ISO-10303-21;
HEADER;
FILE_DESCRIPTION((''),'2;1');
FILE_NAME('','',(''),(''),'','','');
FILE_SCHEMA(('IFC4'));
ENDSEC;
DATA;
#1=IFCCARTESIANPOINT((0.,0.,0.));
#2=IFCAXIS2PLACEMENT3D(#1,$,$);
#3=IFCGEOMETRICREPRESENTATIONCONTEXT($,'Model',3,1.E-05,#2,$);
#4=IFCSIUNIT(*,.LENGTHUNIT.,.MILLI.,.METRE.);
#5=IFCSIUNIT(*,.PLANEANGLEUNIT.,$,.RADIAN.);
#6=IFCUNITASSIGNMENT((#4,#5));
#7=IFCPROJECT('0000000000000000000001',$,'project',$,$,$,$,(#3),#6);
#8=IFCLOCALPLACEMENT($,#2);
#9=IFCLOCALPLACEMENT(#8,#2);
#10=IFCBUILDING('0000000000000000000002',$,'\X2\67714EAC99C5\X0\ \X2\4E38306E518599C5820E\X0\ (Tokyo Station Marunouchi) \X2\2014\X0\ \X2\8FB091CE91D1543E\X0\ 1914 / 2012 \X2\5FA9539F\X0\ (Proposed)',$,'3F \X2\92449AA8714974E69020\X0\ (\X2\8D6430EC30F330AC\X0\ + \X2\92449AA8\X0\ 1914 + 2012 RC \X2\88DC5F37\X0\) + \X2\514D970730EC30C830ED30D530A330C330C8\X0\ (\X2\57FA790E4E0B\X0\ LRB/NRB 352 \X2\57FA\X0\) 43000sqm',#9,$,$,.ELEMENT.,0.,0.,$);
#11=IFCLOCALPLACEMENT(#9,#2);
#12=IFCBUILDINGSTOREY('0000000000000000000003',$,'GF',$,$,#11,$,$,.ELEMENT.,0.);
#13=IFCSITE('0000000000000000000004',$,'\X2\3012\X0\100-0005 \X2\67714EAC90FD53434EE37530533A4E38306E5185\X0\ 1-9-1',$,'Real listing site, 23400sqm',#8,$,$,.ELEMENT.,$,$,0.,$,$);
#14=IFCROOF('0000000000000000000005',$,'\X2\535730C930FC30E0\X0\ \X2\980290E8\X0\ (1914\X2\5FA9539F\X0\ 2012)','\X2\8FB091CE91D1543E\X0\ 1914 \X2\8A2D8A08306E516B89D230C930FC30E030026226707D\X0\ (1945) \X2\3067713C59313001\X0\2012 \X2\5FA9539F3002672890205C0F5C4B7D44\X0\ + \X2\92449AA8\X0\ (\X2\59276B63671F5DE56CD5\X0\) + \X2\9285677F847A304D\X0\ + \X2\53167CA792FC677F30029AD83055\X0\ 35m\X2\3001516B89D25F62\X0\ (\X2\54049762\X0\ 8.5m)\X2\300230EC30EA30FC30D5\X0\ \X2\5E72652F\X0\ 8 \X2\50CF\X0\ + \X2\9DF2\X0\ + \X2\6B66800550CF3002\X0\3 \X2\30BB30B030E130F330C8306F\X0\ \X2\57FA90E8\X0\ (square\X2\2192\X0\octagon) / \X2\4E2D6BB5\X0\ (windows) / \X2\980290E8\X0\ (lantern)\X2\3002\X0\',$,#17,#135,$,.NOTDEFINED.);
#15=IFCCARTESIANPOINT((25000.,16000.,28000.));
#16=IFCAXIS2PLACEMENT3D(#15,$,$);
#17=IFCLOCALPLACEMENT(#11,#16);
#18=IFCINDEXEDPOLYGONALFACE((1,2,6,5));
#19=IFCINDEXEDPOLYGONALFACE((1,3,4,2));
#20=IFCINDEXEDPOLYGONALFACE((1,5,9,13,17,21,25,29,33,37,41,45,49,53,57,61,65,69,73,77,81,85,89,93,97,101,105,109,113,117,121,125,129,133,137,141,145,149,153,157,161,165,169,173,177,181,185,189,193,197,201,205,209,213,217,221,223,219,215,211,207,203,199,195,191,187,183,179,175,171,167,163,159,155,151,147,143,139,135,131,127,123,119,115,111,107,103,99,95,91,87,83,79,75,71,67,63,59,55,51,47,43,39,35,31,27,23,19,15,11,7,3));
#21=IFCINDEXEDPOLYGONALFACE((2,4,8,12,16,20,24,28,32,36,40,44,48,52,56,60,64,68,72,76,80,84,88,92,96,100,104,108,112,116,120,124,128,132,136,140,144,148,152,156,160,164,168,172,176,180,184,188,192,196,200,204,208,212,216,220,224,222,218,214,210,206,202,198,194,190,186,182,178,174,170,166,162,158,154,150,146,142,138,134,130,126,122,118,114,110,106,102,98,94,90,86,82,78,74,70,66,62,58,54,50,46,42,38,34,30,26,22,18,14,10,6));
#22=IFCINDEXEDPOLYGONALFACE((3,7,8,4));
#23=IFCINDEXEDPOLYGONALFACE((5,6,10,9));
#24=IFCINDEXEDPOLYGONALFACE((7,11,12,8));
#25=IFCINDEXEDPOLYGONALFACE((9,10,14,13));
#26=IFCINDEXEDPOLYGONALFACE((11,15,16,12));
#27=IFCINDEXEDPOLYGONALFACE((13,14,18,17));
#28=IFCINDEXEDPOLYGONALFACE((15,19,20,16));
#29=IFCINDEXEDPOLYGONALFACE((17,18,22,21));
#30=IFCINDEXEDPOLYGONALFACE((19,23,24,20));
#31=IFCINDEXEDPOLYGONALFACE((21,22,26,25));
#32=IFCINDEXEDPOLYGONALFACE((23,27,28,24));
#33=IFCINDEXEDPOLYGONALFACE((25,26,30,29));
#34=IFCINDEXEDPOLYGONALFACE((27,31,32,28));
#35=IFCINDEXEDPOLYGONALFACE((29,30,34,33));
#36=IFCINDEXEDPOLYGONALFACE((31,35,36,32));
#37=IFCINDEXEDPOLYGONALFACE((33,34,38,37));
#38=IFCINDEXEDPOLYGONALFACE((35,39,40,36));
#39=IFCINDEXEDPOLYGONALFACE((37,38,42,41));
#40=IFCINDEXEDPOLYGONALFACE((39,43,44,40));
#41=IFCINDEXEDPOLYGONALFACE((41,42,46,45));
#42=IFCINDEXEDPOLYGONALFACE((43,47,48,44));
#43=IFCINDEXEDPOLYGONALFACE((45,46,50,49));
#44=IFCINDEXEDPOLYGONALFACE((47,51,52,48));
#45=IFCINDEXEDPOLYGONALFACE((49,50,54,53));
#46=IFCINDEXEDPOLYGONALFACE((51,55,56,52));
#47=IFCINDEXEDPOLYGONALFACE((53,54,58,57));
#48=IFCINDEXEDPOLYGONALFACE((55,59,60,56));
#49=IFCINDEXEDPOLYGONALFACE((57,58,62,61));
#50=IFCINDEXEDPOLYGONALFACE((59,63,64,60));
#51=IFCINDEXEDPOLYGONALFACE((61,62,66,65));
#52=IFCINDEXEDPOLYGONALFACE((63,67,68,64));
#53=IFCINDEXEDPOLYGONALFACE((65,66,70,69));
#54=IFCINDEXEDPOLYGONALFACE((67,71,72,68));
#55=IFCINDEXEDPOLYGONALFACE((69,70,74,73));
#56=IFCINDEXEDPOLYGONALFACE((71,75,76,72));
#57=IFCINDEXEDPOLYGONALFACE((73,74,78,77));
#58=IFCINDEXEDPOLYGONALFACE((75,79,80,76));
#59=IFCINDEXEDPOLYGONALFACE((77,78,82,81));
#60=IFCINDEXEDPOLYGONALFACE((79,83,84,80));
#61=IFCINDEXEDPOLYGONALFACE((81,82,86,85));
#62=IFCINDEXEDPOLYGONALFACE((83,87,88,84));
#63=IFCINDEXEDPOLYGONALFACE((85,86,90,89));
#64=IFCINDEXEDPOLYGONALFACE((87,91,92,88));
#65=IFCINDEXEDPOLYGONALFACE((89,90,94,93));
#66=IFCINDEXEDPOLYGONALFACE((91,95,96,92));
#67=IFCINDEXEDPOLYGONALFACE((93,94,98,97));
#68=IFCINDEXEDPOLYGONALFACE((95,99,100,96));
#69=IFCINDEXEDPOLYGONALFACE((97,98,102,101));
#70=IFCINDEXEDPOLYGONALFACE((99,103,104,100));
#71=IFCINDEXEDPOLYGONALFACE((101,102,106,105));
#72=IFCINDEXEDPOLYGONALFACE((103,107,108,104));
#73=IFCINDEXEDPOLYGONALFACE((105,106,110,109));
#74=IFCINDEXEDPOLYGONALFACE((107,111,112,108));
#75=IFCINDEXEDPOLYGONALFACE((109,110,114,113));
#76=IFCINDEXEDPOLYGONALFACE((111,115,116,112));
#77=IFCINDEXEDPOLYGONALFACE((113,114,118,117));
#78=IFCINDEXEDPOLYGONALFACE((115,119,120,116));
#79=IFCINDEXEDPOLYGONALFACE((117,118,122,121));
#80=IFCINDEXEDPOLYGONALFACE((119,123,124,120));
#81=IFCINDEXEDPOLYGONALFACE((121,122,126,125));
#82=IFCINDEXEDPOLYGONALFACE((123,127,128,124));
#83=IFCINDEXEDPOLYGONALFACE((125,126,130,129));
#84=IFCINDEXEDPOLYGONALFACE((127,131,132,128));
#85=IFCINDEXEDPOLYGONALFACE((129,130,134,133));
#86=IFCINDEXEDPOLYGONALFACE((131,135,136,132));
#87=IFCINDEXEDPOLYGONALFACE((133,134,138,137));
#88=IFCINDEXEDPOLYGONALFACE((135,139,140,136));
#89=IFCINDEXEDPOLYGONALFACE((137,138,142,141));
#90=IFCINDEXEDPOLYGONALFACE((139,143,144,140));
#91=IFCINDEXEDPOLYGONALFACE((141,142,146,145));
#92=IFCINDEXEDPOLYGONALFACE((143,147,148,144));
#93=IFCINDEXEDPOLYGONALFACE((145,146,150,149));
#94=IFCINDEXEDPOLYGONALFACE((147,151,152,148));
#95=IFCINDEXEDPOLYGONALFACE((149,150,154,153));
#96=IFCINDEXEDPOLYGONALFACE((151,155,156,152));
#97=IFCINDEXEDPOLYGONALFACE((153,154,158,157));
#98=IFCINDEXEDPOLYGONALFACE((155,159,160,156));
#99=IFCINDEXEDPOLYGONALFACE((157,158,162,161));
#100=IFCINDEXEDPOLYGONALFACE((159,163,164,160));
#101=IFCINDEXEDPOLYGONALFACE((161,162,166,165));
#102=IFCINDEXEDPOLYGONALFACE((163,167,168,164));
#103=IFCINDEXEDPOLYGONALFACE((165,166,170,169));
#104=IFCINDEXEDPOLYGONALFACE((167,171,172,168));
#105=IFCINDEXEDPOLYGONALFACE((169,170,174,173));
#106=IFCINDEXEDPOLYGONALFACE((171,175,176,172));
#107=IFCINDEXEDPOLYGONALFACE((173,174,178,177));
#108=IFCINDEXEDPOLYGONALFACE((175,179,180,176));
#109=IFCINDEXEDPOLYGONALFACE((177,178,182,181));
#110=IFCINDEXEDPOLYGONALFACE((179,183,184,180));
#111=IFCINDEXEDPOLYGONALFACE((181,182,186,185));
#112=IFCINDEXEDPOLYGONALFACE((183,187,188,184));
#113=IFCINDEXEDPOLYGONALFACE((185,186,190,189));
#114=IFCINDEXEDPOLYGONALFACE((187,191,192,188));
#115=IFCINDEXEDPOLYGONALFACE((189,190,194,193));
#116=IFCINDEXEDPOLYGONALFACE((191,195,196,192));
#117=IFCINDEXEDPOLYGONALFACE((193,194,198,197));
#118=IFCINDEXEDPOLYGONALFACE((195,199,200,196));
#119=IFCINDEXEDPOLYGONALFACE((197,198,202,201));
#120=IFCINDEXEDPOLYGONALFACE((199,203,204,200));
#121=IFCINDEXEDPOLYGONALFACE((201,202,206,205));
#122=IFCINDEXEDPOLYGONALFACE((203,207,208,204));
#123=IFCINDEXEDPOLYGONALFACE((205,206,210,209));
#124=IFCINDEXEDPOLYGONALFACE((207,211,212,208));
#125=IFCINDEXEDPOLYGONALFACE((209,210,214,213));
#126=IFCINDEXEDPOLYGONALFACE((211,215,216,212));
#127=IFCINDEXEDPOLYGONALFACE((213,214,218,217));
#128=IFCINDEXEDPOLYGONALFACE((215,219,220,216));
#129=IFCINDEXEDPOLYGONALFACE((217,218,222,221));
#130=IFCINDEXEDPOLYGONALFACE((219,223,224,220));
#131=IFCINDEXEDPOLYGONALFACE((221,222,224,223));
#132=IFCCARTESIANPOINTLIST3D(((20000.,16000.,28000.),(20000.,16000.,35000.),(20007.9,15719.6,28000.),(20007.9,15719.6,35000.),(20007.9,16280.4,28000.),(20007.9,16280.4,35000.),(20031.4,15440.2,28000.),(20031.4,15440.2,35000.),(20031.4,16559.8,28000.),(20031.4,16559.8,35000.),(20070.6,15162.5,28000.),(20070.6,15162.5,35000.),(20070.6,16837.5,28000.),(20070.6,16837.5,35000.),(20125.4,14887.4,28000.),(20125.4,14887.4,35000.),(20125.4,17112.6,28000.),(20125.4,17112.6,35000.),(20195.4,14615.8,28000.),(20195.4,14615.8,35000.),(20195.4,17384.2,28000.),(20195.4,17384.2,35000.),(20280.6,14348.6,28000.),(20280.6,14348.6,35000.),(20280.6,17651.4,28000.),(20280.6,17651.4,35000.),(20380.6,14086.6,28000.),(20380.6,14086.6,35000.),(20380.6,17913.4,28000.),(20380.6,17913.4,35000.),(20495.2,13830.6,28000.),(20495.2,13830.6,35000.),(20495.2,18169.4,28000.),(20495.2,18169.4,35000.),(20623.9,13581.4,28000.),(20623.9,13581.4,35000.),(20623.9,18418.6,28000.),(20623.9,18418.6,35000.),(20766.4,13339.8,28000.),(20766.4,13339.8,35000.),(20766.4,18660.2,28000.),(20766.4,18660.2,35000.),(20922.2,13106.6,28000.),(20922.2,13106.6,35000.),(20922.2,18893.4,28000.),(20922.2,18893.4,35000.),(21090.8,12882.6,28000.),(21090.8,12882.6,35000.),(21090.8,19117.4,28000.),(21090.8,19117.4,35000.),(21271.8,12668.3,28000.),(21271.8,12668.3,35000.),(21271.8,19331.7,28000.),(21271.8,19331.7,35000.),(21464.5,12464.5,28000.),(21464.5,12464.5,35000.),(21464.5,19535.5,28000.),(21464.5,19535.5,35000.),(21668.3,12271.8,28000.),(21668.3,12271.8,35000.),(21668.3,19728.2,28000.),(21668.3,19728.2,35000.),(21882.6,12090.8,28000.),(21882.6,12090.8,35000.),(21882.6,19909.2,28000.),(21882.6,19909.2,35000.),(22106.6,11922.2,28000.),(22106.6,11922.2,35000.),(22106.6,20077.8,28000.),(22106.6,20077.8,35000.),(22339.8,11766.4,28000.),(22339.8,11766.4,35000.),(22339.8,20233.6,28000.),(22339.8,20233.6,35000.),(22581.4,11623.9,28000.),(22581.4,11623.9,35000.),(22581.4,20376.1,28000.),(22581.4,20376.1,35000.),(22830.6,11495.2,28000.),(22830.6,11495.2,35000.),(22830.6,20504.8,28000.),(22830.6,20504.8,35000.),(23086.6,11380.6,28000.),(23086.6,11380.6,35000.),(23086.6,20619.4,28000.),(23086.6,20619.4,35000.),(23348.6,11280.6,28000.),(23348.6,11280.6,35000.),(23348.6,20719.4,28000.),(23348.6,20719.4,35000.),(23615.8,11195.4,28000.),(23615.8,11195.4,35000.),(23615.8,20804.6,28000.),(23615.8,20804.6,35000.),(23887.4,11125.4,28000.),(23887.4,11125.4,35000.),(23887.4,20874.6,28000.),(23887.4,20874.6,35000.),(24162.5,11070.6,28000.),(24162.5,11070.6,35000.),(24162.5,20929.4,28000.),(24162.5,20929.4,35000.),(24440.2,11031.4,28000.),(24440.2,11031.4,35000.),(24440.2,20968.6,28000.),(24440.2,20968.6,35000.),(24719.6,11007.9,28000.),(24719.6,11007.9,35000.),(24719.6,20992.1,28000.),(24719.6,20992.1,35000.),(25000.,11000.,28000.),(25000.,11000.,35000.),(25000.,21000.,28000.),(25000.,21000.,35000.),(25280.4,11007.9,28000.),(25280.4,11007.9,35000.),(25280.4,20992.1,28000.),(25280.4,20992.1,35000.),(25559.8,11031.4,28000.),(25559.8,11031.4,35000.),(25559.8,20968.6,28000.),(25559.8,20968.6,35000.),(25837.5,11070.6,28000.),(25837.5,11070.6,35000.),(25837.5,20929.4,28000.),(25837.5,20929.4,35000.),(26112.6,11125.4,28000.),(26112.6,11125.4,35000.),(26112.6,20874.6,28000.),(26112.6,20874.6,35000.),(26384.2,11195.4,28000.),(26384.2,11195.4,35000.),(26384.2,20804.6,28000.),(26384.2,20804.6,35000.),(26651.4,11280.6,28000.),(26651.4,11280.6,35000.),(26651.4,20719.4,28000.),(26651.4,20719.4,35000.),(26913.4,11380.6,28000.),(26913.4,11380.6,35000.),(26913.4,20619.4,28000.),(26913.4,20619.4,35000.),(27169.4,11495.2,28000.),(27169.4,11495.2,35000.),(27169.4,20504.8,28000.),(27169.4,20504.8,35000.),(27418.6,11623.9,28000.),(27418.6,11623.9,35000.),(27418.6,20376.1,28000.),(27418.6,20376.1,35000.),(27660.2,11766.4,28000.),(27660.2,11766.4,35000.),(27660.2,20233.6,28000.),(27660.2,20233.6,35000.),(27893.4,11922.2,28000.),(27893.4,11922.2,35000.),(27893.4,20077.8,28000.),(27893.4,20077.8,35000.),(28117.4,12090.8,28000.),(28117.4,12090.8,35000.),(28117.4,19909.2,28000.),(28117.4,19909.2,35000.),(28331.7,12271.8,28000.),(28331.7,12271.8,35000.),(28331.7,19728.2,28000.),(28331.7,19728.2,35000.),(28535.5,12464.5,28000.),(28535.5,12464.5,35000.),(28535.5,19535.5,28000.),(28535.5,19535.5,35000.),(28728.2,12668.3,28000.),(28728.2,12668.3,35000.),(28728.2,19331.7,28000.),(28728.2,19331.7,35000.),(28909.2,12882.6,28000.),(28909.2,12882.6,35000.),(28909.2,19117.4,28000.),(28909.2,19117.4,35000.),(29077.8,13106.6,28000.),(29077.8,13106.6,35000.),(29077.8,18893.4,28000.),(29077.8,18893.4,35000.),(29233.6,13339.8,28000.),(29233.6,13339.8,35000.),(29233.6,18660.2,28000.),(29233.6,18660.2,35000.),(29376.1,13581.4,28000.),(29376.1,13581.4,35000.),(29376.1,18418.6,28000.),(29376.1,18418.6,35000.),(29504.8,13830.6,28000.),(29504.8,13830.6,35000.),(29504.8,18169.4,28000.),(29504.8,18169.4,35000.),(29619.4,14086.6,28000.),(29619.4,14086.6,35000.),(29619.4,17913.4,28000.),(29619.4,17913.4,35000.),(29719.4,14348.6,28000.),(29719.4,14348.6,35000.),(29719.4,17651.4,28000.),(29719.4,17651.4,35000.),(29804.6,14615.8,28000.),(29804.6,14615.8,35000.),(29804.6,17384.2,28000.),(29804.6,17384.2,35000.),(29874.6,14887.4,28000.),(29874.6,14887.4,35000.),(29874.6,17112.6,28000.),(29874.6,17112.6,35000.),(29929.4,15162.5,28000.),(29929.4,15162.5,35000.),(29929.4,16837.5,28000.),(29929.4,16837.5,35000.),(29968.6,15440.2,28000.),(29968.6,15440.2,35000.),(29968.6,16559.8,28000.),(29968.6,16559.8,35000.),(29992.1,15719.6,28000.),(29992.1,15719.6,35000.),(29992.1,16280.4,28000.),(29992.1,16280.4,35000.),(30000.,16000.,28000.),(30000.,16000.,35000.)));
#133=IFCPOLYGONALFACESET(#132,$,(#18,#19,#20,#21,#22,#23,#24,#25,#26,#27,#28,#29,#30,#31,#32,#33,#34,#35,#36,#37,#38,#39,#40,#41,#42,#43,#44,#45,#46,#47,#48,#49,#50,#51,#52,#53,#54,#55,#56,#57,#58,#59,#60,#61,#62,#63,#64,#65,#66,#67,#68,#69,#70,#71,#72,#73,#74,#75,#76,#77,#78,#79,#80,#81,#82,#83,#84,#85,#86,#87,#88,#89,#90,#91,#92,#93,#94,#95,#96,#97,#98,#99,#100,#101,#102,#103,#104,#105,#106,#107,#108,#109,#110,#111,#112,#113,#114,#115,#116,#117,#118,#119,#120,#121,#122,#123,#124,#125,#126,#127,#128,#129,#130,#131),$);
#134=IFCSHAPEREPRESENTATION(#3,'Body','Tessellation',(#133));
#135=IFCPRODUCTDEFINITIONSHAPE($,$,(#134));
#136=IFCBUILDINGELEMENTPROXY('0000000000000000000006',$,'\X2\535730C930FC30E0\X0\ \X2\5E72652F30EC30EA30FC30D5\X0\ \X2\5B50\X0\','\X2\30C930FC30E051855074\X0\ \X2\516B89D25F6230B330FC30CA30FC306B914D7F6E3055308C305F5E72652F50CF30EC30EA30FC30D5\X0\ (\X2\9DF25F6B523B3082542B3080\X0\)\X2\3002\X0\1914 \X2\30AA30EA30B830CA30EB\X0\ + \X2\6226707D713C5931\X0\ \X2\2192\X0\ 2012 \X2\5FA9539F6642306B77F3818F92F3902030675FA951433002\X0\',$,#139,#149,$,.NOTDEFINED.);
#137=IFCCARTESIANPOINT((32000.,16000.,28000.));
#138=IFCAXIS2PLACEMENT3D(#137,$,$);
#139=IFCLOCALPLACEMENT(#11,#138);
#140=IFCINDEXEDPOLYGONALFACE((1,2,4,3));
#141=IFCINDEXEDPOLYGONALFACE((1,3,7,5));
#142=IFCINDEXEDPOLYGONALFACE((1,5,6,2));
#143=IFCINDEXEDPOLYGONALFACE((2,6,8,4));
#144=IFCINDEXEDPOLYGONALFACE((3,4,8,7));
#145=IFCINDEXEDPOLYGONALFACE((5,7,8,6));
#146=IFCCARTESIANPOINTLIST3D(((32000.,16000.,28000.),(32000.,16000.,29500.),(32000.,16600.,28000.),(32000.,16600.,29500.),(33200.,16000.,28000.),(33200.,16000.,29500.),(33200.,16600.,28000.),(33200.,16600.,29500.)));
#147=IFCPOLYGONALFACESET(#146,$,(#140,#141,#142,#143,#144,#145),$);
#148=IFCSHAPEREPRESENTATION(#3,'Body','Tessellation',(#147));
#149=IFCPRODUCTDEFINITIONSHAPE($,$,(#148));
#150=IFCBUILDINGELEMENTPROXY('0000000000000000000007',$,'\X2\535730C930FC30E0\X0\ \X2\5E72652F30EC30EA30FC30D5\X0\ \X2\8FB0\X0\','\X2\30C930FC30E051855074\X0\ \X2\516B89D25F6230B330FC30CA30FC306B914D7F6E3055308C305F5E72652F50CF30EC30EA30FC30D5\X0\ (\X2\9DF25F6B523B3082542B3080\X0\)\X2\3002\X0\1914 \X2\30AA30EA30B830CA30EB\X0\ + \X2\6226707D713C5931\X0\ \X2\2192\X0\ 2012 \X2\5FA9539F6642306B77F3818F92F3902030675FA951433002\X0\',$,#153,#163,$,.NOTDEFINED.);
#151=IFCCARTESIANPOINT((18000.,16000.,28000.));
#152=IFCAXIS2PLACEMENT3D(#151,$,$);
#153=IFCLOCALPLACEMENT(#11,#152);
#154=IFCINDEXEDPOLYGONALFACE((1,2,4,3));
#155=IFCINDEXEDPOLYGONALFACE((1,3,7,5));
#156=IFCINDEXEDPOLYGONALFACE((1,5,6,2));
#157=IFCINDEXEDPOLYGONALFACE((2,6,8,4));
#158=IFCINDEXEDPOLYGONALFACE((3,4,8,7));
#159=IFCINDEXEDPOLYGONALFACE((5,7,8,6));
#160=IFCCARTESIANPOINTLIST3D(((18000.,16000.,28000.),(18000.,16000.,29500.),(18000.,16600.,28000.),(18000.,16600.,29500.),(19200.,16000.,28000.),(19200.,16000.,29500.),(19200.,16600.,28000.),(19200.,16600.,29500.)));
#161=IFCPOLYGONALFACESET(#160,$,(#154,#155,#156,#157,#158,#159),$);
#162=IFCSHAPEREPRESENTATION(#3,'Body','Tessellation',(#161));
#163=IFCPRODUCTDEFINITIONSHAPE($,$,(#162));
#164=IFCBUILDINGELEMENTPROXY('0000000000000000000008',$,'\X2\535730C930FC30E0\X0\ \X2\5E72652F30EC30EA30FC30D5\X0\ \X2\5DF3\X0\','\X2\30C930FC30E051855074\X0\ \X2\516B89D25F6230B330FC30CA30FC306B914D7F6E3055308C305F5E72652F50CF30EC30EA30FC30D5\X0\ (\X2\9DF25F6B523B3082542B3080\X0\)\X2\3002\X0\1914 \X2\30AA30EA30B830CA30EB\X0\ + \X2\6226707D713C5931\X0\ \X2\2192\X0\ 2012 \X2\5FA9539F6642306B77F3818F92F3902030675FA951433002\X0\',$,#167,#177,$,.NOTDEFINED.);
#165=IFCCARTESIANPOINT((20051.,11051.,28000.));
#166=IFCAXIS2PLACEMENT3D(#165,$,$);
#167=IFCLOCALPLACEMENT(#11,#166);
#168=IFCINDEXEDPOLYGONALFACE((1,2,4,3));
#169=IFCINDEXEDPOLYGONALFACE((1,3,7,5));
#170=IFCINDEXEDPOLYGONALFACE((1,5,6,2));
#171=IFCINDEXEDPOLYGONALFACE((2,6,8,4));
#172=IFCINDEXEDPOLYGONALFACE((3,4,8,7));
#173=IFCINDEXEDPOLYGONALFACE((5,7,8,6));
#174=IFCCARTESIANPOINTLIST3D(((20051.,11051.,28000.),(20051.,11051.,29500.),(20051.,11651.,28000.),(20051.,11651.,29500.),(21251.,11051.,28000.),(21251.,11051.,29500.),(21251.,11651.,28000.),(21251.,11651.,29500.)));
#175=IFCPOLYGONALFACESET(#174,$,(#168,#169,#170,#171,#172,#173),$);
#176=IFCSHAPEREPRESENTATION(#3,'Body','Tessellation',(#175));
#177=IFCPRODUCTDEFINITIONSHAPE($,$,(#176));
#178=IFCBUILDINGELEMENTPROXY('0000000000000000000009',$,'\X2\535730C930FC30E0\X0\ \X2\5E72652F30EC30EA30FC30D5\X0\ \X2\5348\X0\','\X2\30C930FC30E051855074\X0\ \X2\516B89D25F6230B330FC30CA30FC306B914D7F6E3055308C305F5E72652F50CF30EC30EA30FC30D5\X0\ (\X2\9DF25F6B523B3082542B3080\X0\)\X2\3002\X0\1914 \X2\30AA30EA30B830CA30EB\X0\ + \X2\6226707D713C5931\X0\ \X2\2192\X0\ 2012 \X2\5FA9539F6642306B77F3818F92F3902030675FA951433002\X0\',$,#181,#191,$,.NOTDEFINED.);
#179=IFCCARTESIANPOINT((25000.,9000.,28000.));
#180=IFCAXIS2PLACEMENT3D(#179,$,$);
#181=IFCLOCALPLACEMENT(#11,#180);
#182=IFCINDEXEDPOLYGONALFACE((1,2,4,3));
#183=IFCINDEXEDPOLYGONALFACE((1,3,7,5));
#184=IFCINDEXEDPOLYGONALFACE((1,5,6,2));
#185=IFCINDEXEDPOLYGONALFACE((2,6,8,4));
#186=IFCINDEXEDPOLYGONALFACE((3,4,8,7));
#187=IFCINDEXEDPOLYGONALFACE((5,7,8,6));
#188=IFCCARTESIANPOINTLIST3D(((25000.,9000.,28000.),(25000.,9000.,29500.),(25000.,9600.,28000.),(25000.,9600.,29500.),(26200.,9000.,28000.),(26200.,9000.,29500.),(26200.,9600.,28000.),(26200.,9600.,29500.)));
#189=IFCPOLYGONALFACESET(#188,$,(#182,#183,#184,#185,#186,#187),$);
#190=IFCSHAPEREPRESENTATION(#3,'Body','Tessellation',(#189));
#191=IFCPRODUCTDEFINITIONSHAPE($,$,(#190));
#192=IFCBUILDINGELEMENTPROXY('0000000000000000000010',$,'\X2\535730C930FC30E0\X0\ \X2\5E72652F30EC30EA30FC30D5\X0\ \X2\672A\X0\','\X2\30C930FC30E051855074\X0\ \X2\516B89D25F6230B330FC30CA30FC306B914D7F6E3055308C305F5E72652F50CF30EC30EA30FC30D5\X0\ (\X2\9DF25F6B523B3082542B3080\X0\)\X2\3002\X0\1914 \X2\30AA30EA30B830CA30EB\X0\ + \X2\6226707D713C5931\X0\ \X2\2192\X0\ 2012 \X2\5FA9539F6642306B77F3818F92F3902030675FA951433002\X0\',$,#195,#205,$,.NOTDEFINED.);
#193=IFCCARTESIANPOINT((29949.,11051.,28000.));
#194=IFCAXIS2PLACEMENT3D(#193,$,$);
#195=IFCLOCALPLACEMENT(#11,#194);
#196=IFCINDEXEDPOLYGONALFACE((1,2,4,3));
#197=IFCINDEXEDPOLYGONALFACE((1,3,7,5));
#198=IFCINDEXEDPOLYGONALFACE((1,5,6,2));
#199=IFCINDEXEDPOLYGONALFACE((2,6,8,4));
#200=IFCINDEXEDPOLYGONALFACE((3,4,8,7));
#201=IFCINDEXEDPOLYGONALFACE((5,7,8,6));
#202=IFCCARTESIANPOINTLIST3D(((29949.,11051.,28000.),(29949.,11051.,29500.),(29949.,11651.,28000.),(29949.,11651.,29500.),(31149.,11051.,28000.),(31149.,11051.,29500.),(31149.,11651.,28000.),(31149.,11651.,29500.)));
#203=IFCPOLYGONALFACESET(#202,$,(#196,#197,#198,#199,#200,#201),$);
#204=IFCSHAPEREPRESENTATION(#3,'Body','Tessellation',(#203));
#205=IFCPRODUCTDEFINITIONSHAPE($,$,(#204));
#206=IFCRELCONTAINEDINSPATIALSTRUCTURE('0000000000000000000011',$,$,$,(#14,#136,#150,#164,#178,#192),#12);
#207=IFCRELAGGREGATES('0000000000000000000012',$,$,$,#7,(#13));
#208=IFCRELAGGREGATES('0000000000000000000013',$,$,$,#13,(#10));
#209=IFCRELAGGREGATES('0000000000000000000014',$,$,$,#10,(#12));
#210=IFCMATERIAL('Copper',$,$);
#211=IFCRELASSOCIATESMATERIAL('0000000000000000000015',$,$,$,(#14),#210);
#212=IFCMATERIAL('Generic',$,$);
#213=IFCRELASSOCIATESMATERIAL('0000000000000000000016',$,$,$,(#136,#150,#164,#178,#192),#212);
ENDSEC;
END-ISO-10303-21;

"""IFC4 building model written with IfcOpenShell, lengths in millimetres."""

from ifc_helpers import new_model, si_unit, frame, frame_2d, origin, origin_2d, place, context, project, spatial, rectangle, circle, extrude, material, element, save


model = new_model("IFC4")

# Units and contexts
model_context = context("Model", 3, precision=1e-05, world=origin())
ifc_project = project(units=[si_unit("LENGTHUNIT", "METRE", prefix="MILLI"), si_unit("PLANEANGLEUNIT", "RADIAN")], contexts=[model_context])

# Site, building, storey
site_placement = place(None, origin())
site = spatial("IfcSite", under=ifc_project, at=site_placement, Name="〒100-0005 東京都千代田区丸の内 1-9-1", ObjectType="Real listing site, 23400sqm", CompositionType="ELEMENT", RefElevation=0.0)
building_placement = place(site_placement, origin())
building = spatial("IfcBuilding", under=site, at=building_placement, Name="東京駅 丸の内駅舎 (Tokyo Station Marunouchi) — 辰野金吾 1914 / 2012 復原 (Proposed)", ObjectType="3F 鉄骨煉瓦造 (赤レンガ + 鉄骨 1914 + 2012 RC 補強) + 免震レトロフィット (基礎下 LRB/NRB 352 基) 43000sqm", CompositionType="ELEMENT", ElevationOfRefHeight=0.0, ElevationOfTerrain=0.0)
storey_placement = place(building_placement, origin())
storey = spatial("IfcBuildingStorey", under=building, at=storey_placement, Name="GF", CompositionType="ELEMENT", Elevation=0.0)

# Shared definitions
ifc_material_1 = material(Name="Generic")

# Roof
ifc_material_2 = material(Name="Copper")
roof_1_placement = place(storey_placement, frame((25000.0, 16000.0, 28000.0)))
element("IfcRoof", 1, at=roof_1_placement, inside=storey, material=ifc_material_2, Name="南ドーム 頂部 (1914復原 2012)", Description="辰野金吾 1914 設計の八角ドーム。戦災 (1945) で焼失、2012 復原。木造小屋組 + 鉄骨 (大正期工法) + 銅板葺き + 化粧鋼板。高さ 35m、八角形 (各面 8.5m)。レリーフ 干支 8 像 + 鷲 + 武者像。3 セグメントは 基部 (square→octagon) / 中段 (windows) / 頂部 (lantern)。", PredefinedType="NOTDEFINED", context=model_context, shape_type="SweptSolid", body=[
    extrude(circle(Radius=5000.0, at=origin_2d()), frame((25000.0, 16000.0, 28000.0)), (0.0, 0.0, 1.0), 7000.0),
])

# Building element proxies
proxy_1_placement = place(storey_placement, frame((32000.0, 16000.0, 28000.0)))
element("IfcBuildingElementProxy", 2, at=proxy_1_placement, inside=storey, material=ifc_material_1, Name="南ドーム 干支レリーフ 子", Description="ドーム内側 八角形コーナーに配置された干支像レリーフ (鷲彫刻も含む)。1914 オリジナル + 戦災焼失 → 2012 復原時に石膏鋳造で復元。", PredefinedType="NOTDEFINED", context=model_context, shape_type="SweptSolid", body=[
    extrude(rectangle(XDim=1200.0, YDim=600.0, at=frame_2d((600.0, 300.0))), frame((32000.0, 16000.0, 28000.0)), (0.0, 0.0, 1.0), 1500.0),
])
proxy_2_placement = place(storey_placement, frame((18000.0, 16000.0, 28000.0)))
element("IfcBuildingElementProxy", 3, at=proxy_2_placement, inside=storey, material=ifc_material_1, Name="南ドーム 干支レリーフ 辰", Description="ドーム内側 八角形コーナーに配置された干支像レリーフ (鷲彫刻も含む)。1914 オリジナル + 戦災焼失 → 2012 復原時に石膏鋳造で復元。", PredefinedType="NOTDEFINED", context=model_context, shape_type="SweptSolid", body=[
    extrude(rectangle(XDim=1200.0, YDim=600.0, at=frame_2d((600.0, 300.0))), frame((18000.0, 16000.0, 28000.0)), (0.0, 0.0, 1.0), 1500.0),
])
proxy_3_placement = place(storey_placement, frame((20051.0, 11051.0, 28000.0)))
element("IfcBuildingElementProxy", 4, at=proxy_3_placement, inside=storey, material=ifc_material_1, Name="南ドーム 干支レリーフ 巳", Description="ドーム内側 八角形コーナーに配置された干支像レリーフ (鷲彫刻も含む)。1914 オリジナル + 戦災焼失 → 2012 復原時に石膏鋳造で復元。", PredefinedType="NOTDEFINED", context=model_context, shape_type="SweptSolid", body=[
    extrude(rectangle(XDim=1200.0, YDim=600.0, at=frame_2d((600.0, 300.0))), frame((20051.0, 11051.0, 28000.0)), (0.0, 0.0, 1.0), 1500.0),
])
proxy_4_placement = place(storey_placement, frame((25000.0, 9000.0, 28000.0)))
element("IfcBuildingElementProxy", 5, at=proxy_4_placement, inside=storey, material=ifc_material_1, Name="南ドーム 干支レリーフ 午", Description="ドーム内側 八角形コーナーに配置された干支像レリーフ (鷲彫刻も含む)。1914 オリジナル + 戦災焼失 → 2012 復原時に石膏鋳造で復元。", PredefinedType="NOTDEFINED", context=model_context, shape_type="SweptSolid", body=[
    extrude(rectangle(XDim=1200.0, YDim=600.0, at=frame_2d((600.0, 300.0))), frame((25000.0, 9000.0, 28000.0)), (0.0, 0.0, 1.0), 1500.0),
])
proxy_5_placement = place(storey_placement, frame((29949.0, 11051.0, 28000.0)))
element("IfcBuildingElementProxy", 6, at=proxy_5_placement, inside=storey, material=ifc_material_1, Name="南ドーム 干支レリーフ 未", Description="ドーム内側 八角形コーナーに配置された干支像レリーフ (鷲彫刻も含む)。1914 オリジナル + 戦災焼失 → 2012 復原時に石膏鋳造で復元。", PredefinedType="NOTDEFINED", context=model_context, shape_type="SweptSolid", body=[
    extrude(rectangle(XDim=1200.0, YDim=600.0, at=frame_2d((600.0, 300.0))), frame((29949.0, 11051.0, 28000.0)), (0.0, 0.0, 1.0), 1500.0),
])

save(model, "model.ifc")
